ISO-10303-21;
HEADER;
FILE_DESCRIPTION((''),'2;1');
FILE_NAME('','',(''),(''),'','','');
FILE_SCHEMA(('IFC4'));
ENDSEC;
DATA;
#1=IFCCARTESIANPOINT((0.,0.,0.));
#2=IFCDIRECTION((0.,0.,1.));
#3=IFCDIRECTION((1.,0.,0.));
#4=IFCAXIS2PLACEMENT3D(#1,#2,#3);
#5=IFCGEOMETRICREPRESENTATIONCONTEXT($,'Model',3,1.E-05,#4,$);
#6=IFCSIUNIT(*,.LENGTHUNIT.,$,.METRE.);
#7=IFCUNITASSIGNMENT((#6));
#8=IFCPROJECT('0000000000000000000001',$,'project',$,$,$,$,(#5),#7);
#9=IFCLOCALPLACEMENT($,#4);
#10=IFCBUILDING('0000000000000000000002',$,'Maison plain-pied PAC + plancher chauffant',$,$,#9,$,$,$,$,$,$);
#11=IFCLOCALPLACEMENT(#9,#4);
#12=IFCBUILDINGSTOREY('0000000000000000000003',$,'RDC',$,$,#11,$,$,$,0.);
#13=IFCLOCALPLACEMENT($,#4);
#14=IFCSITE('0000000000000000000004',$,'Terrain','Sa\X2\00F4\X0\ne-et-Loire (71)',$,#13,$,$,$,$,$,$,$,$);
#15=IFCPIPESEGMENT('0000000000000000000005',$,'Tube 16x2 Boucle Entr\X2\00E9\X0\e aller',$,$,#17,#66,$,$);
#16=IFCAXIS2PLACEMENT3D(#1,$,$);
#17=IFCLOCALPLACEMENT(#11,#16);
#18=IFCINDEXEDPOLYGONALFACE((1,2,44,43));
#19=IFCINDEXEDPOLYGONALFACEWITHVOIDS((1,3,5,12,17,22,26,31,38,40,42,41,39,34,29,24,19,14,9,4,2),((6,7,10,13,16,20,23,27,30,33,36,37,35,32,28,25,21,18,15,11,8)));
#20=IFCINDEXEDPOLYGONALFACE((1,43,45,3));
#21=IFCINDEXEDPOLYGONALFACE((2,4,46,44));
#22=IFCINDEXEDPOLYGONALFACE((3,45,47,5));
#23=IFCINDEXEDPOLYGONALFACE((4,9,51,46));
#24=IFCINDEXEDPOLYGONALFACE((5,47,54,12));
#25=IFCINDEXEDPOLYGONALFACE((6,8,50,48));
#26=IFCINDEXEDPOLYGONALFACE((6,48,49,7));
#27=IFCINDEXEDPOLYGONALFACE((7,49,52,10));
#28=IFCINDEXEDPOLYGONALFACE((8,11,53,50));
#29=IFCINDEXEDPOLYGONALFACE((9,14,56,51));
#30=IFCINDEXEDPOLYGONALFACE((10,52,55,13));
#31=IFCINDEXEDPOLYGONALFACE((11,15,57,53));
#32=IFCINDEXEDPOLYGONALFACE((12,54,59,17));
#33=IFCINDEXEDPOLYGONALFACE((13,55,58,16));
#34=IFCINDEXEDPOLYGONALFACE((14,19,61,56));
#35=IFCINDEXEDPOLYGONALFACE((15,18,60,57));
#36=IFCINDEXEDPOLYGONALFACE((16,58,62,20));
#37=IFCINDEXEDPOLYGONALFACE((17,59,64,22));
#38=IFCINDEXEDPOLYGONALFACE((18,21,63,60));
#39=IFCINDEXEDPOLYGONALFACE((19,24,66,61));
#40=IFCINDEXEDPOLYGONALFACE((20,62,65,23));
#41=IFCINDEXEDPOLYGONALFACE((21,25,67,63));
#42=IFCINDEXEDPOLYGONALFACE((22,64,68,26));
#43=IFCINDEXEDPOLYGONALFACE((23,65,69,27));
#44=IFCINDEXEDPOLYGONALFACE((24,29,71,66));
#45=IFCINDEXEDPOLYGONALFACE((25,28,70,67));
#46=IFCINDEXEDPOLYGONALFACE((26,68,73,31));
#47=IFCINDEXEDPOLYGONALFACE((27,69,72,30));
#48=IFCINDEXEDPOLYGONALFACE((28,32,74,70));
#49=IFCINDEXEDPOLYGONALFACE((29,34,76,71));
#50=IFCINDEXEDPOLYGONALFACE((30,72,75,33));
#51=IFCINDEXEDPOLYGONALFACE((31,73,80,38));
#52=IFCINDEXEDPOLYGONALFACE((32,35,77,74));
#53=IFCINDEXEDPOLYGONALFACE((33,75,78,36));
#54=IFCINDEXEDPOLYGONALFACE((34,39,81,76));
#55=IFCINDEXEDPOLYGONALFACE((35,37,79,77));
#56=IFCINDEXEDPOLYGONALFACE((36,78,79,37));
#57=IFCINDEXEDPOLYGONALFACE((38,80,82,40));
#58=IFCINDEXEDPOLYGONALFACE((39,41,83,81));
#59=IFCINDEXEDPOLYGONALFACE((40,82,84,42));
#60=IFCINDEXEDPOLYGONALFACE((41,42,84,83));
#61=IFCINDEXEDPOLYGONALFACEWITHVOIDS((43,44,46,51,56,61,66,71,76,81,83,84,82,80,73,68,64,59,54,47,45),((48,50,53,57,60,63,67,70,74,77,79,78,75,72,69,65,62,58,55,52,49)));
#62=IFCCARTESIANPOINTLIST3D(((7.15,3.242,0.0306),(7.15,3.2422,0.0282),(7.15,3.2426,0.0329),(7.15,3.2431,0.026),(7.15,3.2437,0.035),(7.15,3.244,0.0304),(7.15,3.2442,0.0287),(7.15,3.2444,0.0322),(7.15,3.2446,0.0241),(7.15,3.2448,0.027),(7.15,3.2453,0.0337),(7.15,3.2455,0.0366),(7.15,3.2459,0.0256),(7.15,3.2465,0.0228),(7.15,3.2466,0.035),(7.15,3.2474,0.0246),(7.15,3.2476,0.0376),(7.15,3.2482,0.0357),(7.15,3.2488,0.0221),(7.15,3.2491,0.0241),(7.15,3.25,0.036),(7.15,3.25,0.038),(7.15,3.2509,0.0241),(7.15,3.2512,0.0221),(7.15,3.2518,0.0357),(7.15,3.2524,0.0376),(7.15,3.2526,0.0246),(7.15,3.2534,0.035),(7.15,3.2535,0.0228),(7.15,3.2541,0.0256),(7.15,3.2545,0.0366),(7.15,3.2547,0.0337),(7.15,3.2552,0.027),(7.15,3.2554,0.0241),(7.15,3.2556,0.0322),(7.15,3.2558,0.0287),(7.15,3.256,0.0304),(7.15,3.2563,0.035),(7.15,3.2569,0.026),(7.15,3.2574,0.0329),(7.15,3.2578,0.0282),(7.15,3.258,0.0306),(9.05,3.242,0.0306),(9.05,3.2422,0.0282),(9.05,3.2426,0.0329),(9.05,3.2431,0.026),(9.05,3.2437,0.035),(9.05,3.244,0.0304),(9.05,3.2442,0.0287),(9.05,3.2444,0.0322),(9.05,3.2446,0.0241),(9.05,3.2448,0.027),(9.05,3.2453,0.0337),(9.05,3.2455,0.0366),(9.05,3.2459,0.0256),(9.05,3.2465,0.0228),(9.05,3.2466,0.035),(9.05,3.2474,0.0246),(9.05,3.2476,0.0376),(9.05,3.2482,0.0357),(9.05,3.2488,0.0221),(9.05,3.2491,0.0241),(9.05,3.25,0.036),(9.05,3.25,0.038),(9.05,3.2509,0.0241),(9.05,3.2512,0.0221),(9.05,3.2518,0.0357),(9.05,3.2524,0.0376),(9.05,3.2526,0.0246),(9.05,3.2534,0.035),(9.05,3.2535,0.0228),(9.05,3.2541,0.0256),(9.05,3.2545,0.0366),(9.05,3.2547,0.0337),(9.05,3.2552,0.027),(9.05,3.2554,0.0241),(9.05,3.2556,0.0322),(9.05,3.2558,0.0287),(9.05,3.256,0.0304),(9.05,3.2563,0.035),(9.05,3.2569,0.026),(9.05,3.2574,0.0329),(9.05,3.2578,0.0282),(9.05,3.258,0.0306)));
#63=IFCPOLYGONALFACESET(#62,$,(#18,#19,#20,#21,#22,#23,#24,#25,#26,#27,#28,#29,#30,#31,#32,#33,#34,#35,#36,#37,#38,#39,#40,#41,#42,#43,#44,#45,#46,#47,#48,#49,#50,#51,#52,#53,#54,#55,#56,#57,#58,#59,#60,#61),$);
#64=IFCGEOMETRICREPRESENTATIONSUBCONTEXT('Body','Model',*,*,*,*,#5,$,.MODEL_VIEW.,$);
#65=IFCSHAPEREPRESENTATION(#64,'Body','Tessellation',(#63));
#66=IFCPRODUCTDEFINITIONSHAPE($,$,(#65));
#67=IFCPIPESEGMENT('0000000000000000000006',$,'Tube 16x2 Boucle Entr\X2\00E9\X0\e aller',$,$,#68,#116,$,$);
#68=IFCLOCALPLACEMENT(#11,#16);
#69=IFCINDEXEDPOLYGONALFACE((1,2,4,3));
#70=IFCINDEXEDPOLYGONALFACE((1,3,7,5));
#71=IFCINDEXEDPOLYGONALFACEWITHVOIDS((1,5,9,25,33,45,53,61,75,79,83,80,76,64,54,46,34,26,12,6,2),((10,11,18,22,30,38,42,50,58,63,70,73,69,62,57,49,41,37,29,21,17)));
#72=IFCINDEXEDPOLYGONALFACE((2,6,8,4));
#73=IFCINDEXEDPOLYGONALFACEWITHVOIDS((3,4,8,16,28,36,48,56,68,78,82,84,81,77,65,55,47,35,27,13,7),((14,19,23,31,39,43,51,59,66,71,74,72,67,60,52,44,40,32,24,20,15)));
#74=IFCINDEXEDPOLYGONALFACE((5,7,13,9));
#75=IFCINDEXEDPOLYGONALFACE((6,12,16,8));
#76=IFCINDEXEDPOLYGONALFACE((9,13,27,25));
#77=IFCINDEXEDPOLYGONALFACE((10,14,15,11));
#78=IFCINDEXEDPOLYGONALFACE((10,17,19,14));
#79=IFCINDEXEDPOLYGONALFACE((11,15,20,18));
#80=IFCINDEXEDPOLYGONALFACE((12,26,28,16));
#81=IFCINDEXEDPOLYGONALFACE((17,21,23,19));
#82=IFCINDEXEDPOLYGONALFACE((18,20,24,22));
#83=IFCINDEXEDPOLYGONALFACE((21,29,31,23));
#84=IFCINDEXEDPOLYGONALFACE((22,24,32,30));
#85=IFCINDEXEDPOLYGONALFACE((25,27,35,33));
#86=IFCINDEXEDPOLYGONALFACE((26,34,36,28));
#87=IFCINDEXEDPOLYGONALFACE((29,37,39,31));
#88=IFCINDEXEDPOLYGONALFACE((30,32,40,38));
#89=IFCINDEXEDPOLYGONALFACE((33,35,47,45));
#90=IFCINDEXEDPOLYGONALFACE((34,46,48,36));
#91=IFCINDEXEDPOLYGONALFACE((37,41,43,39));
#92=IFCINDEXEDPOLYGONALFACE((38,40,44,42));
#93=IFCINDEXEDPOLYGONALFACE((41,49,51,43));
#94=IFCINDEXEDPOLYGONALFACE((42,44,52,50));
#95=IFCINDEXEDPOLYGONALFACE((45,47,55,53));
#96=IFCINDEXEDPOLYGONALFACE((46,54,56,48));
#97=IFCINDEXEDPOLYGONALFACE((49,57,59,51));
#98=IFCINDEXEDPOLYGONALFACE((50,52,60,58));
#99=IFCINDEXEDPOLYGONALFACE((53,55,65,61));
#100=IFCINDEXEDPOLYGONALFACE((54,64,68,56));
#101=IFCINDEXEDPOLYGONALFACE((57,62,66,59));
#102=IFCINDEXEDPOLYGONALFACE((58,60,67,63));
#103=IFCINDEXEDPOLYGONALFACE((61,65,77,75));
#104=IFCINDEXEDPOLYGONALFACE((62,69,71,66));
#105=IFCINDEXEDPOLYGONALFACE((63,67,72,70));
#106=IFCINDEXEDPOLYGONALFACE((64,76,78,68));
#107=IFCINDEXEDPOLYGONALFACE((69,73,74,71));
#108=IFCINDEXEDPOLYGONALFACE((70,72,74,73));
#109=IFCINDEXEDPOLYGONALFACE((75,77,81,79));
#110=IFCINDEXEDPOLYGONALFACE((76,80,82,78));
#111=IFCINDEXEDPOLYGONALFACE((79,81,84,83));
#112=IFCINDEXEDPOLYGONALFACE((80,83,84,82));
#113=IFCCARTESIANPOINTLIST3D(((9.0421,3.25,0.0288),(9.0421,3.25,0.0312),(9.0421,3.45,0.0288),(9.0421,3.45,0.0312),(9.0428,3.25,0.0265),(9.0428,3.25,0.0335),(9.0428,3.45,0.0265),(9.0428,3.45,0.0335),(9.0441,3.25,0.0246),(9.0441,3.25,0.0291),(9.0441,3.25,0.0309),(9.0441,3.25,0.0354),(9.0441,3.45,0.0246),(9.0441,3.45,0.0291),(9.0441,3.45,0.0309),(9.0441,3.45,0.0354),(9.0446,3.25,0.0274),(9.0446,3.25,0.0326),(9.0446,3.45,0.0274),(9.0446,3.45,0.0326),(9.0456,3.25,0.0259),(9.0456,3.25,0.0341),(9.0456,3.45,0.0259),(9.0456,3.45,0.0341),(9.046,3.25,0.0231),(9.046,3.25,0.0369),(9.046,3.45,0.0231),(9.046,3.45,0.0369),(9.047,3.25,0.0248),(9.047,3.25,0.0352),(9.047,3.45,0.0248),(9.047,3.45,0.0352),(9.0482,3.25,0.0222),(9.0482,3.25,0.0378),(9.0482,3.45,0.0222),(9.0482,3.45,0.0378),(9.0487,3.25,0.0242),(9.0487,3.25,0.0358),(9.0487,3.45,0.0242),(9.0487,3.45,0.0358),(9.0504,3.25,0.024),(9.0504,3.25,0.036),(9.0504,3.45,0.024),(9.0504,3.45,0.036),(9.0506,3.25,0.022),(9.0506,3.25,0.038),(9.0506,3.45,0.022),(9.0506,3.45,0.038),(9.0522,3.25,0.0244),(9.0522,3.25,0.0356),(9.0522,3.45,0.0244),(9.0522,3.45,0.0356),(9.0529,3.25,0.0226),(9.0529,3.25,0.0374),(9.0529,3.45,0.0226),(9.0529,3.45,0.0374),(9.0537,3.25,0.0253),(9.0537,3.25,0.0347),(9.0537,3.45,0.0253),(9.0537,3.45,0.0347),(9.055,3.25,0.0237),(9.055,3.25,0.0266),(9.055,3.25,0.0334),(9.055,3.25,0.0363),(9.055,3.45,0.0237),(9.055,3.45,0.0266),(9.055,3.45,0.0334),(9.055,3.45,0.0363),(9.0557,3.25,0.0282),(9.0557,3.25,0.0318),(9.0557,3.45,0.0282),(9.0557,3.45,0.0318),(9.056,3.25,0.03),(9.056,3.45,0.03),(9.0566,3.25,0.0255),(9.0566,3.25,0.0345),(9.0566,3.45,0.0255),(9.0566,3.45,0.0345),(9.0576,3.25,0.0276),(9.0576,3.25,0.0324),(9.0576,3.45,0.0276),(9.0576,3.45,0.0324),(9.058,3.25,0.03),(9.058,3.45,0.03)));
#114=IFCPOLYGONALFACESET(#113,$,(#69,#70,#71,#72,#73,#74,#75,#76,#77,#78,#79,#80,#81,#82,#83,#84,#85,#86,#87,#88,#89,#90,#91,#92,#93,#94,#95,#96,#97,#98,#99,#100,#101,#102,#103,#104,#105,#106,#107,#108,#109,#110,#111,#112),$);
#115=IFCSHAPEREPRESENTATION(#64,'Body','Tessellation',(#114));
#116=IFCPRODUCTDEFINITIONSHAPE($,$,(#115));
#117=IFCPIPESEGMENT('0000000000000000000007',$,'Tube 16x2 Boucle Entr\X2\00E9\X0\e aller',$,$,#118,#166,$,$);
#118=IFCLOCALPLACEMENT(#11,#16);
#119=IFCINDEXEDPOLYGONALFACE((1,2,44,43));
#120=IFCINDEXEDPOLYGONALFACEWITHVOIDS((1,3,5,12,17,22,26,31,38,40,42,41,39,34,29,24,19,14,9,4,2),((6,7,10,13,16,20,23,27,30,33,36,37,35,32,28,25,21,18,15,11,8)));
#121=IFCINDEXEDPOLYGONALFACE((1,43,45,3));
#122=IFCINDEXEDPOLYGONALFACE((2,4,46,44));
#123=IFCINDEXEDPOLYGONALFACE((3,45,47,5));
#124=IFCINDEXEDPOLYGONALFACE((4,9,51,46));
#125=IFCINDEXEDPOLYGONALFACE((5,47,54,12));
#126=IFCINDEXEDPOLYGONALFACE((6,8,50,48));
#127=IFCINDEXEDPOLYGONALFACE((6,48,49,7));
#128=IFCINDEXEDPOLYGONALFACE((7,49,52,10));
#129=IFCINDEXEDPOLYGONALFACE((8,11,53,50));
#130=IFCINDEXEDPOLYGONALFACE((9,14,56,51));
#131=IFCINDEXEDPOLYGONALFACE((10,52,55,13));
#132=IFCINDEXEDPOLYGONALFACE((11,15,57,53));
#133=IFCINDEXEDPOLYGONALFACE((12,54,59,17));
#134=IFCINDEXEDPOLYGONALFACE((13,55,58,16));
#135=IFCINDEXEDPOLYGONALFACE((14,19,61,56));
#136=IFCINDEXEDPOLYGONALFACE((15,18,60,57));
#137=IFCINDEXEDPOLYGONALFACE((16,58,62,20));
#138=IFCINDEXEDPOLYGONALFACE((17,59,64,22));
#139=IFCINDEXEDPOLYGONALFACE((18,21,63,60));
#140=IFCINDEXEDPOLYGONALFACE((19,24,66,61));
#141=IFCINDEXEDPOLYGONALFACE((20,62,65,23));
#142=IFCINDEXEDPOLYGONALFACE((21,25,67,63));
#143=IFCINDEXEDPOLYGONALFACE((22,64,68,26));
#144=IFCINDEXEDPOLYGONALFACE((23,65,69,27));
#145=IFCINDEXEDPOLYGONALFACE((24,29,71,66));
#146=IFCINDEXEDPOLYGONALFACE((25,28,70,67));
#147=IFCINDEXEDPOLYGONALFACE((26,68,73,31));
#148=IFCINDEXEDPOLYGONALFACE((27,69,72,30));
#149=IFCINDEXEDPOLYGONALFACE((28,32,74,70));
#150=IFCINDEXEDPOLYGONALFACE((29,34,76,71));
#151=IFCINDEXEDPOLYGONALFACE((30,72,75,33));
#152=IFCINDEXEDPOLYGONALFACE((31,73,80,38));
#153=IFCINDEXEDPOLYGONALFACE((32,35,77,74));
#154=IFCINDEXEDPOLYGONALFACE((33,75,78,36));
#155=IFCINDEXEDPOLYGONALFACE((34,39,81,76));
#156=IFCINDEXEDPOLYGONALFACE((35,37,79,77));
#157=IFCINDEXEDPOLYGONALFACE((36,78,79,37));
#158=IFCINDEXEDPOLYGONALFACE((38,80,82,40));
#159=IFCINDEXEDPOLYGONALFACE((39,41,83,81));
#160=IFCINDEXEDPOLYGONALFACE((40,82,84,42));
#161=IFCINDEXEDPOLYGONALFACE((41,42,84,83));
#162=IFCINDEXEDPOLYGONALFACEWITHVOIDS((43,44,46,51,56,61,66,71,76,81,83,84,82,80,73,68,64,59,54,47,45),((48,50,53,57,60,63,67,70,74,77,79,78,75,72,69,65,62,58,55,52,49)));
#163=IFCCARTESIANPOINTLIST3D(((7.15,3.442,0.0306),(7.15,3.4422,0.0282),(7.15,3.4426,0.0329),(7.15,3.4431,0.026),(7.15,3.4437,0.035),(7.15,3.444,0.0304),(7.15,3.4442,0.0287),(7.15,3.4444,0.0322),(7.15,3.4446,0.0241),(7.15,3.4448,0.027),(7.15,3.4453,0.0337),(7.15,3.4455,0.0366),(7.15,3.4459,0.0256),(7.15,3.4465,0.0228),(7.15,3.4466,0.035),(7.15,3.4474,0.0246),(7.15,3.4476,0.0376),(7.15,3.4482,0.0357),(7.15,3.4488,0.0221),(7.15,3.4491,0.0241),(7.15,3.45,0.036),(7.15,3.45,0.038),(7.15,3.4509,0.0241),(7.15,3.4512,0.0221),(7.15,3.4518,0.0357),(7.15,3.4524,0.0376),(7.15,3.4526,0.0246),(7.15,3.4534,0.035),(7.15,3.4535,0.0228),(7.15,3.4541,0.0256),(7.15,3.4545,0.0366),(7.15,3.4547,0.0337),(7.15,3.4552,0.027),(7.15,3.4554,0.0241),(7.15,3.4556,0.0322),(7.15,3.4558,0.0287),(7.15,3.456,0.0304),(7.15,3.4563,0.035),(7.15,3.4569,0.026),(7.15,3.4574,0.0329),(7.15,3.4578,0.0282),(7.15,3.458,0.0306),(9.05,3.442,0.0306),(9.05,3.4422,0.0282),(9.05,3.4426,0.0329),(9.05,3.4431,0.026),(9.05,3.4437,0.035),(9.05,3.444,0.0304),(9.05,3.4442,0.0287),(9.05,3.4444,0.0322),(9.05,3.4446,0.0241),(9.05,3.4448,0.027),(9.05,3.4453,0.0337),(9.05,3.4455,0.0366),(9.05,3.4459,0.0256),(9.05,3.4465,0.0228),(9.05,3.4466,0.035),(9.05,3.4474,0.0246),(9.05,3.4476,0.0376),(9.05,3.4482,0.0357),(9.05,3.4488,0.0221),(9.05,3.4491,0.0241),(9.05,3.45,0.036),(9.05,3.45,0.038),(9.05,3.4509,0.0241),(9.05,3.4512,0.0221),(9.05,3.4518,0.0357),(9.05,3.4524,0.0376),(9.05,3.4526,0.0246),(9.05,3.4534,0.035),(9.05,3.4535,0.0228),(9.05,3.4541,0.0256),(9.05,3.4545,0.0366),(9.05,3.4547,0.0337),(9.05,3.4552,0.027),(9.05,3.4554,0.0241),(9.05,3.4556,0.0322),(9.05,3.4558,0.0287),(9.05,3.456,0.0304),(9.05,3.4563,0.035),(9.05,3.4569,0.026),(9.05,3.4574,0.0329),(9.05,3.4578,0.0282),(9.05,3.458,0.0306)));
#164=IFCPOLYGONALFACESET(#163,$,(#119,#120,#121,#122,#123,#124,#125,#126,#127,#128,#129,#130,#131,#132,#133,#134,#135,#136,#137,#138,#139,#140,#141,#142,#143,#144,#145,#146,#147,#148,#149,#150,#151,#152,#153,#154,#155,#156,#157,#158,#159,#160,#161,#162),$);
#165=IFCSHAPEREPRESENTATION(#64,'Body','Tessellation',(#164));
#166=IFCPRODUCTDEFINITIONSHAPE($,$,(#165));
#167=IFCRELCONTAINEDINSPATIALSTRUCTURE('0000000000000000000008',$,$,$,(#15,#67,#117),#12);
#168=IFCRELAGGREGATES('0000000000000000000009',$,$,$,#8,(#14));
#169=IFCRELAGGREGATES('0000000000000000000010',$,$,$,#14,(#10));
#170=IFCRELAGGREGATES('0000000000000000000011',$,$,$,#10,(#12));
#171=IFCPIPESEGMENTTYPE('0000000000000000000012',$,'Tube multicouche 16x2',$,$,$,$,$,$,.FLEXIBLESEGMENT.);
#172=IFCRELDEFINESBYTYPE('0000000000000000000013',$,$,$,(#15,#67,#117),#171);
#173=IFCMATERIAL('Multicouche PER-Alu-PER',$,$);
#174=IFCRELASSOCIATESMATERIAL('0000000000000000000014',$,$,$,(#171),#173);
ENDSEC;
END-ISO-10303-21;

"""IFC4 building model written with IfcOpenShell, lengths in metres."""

from ifc_helpers import new_model, si_unit, frame, origin_with_axes, place, context, subcontext, project, spatial, hollow_circle, extrude, material, type_object, element, save


model = new_model("IFC4")

# Units and contexts
model_context = context("Model", 3, precision=1e-05, world=origin_with_axes())
body_context = subcontext(model_context, "Body", "Model", "MODEL_VIEW")
ifc_project = project(units=[si_unit("LENGTHUNIT", "METRE")], contexts=[model_context])

# Site, building, storey
site_placement = place(None, origin_with_axes())
site = spatial("IfcSite", under=ifc_project, at=site_placement, Name="Terrain", Description="Saône-et-Loire (71)")
building_placement = place(None, origin_with_axes())
building = spatial("IfcBuilding", under=site, at=building_placement, Name="Maison plain-pied PAC + plancher chauffant")
storey_placement = place(building_placement, origin_with_axes())
storey = spatial("IfcBuildingStorey", under=building, at=storey_placement, Name="RDC", Elevation=0.0)

# Pipe segments
ifc_material = material(Name="Multicouche PER-Alu-PER")
pipe_segment_type = type_object("IfcPipeSegmentType", Name="Tube multicouche 16x2", PredefinedType="FLEXIBLESEGMENT", material=ifc_material)
pipe_segment_1_placement = place(storey_placement, frame((7.15, 3.25, 0.03), z_axis=(1.0, 0.0, 0.0), x_axis=(0.0, 0.0, 1.0)))
element("IfcPipeSegment", 1, at=pipe_segment_1_placement, inside=storey, type_object=pipe_segment_type, Name="Tube 16x2 Boucle Entrée aller", context=body_context, shape_type="SweptSolid", body=[
    extrude(hollow_circle(Radius=0.008, WallThickness=0.002), origin_with_axes(), (0.0, 0.0, 1.0), 1.9),
])
pipe_segment_2_placement = place(storey_placement, frame((9.05, 3.25, 0.03), z_axis=(0.0, 1.0, 0.0), x_axis=(1.0, 0.0, 0.0)))
element("IfcPipeSegment", 2, at=pipe_segment_2_placement, inside=storey, type_object=pipe_segment_type, Name="Tube 16x2 Boucle Entrée aller", context=body_context, shape_type="SweptSolid", body=[
    extrude(hollow_circle(Radius=0.008, WallThickness=0.002), origin_with_axes(), (0.0, 0.0, 1.0), 0.2),
])
pipe_segment_3_placement = place(storey_placement, frame((9.05, 3.45, 0.03), z_axis=(-1.0, 0.0, 0.0), x_axis=(0.0, 0.0, 1.0)))
element("IfcPipeSegment", 3, at=pipe_segment_3_placement, inside=storey, type_object=pipe_segment_type, Name="Tube 16x2 Boucle Entrée aller", context=body_context, shape_type="SweptSolid", body=[
    extrude(hollow_circle(Radius=0.008, WallThickness=0.002), origin_with_axes(), (0.0, 0.0, 1.0), 1.9),
])

save(model, "model.ifc")
